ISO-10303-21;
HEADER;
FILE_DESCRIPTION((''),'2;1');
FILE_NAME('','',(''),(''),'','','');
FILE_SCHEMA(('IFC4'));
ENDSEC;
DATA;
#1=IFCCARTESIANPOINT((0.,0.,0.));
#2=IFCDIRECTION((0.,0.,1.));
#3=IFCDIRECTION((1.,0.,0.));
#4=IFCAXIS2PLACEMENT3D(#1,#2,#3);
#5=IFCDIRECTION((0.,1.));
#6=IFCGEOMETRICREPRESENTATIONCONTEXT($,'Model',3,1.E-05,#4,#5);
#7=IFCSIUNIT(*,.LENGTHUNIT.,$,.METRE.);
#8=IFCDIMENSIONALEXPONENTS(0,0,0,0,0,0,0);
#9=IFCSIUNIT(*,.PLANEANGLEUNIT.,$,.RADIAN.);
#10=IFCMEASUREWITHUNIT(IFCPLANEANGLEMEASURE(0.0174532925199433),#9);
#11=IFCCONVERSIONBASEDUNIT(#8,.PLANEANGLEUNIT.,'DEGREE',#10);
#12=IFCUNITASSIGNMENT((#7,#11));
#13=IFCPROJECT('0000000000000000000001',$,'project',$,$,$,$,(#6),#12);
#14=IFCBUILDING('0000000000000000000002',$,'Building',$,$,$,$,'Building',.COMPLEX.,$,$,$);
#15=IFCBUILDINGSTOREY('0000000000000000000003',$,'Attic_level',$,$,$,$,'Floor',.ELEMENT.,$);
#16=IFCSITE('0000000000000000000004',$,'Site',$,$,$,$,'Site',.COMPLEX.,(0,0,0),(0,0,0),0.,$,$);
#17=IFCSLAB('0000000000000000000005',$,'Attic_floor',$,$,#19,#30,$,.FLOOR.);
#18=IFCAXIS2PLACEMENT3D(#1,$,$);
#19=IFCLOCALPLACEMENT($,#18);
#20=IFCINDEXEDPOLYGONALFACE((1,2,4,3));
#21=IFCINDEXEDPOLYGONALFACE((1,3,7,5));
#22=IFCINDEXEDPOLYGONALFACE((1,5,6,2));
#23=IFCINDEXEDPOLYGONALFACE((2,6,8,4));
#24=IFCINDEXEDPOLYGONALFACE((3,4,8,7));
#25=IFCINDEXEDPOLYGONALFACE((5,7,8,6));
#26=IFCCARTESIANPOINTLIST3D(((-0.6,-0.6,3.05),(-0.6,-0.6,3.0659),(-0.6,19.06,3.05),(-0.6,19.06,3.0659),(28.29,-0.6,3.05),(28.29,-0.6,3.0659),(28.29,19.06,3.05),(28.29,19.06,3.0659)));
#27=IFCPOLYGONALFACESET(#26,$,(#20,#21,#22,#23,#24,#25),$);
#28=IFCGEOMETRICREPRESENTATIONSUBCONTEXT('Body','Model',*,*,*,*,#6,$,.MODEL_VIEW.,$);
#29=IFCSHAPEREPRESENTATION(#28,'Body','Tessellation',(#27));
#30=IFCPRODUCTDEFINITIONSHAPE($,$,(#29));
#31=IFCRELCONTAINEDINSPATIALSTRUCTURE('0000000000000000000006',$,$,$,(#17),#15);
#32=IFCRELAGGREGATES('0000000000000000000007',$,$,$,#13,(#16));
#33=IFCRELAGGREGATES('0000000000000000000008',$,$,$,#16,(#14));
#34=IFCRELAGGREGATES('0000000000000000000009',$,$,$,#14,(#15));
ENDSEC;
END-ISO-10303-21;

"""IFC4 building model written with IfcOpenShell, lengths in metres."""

from ifc_helpers import new_model, entity, si_unit, converted_unit, direction, frame, frame_2d, origin_with_axes, place, context, subcontext, project, spatial, rectangle, extrude, element, save


model = new_model("IFC4")

# Units and contexts
model_context = context("Model", 3, precision=1e-05, world=origin_with_axes(), true_north=direction((0.0, 1.0)))
body_context = subcontext(model_context, "Body", "Model", "MODEL_VIEW")
ifc_project = project(units=[si_unit("LENGTHUNIT", "METRE"), converted_unit("PLANEANGLEUNIT", "DEGREE", entity("IfcPlaneAngleMeasure", 0.0174532925199433), si_unit("PLANEANGLEUNIT", "RADIAN"), dimensions=[0, 0, 0, 0, 0, 0, 0])], contexts=[model_context])

# Site, building, storey
site = spatial("IfcSite", under=ifc_project, Name="Site", LongName="Site", CompositionType="COMPLEX", RefLatitude=(0, 0, 0), RefLongitude=(0, 0, 0), RefElevation=0.0)
building = spatial("IfcBuilding", under=site, Name="Building", LongName="Building", CompositionType="COMPLEX")
storey = spatial("IfcBuildingStorey", under=building, Name="Attic_level", LongName="Floor", CompositionType="ELEMENT")

# Slab
placement = place(None, origin_with_axes())
element("IfcSlab", 1, at=placement, inside=storey, Name="Attic_floor", PredefinedType="FLOOR", context=body_context, shape_type="SweptSolid", body=[
    extrude(rectangle(XDim=19.66, YDim=28.89, at=frame_2d((0.0, 0.0), x_axis=(0.0, 1.0))), frame((13.845, 9.23, 3.05), z_axis=(0.0, 0.0, 1.0), x_axis=(1.0, 0.0, 0.0)), (0.0, 0.0, 1.0), 0.0159),
])

save(model, "model.ifc")
